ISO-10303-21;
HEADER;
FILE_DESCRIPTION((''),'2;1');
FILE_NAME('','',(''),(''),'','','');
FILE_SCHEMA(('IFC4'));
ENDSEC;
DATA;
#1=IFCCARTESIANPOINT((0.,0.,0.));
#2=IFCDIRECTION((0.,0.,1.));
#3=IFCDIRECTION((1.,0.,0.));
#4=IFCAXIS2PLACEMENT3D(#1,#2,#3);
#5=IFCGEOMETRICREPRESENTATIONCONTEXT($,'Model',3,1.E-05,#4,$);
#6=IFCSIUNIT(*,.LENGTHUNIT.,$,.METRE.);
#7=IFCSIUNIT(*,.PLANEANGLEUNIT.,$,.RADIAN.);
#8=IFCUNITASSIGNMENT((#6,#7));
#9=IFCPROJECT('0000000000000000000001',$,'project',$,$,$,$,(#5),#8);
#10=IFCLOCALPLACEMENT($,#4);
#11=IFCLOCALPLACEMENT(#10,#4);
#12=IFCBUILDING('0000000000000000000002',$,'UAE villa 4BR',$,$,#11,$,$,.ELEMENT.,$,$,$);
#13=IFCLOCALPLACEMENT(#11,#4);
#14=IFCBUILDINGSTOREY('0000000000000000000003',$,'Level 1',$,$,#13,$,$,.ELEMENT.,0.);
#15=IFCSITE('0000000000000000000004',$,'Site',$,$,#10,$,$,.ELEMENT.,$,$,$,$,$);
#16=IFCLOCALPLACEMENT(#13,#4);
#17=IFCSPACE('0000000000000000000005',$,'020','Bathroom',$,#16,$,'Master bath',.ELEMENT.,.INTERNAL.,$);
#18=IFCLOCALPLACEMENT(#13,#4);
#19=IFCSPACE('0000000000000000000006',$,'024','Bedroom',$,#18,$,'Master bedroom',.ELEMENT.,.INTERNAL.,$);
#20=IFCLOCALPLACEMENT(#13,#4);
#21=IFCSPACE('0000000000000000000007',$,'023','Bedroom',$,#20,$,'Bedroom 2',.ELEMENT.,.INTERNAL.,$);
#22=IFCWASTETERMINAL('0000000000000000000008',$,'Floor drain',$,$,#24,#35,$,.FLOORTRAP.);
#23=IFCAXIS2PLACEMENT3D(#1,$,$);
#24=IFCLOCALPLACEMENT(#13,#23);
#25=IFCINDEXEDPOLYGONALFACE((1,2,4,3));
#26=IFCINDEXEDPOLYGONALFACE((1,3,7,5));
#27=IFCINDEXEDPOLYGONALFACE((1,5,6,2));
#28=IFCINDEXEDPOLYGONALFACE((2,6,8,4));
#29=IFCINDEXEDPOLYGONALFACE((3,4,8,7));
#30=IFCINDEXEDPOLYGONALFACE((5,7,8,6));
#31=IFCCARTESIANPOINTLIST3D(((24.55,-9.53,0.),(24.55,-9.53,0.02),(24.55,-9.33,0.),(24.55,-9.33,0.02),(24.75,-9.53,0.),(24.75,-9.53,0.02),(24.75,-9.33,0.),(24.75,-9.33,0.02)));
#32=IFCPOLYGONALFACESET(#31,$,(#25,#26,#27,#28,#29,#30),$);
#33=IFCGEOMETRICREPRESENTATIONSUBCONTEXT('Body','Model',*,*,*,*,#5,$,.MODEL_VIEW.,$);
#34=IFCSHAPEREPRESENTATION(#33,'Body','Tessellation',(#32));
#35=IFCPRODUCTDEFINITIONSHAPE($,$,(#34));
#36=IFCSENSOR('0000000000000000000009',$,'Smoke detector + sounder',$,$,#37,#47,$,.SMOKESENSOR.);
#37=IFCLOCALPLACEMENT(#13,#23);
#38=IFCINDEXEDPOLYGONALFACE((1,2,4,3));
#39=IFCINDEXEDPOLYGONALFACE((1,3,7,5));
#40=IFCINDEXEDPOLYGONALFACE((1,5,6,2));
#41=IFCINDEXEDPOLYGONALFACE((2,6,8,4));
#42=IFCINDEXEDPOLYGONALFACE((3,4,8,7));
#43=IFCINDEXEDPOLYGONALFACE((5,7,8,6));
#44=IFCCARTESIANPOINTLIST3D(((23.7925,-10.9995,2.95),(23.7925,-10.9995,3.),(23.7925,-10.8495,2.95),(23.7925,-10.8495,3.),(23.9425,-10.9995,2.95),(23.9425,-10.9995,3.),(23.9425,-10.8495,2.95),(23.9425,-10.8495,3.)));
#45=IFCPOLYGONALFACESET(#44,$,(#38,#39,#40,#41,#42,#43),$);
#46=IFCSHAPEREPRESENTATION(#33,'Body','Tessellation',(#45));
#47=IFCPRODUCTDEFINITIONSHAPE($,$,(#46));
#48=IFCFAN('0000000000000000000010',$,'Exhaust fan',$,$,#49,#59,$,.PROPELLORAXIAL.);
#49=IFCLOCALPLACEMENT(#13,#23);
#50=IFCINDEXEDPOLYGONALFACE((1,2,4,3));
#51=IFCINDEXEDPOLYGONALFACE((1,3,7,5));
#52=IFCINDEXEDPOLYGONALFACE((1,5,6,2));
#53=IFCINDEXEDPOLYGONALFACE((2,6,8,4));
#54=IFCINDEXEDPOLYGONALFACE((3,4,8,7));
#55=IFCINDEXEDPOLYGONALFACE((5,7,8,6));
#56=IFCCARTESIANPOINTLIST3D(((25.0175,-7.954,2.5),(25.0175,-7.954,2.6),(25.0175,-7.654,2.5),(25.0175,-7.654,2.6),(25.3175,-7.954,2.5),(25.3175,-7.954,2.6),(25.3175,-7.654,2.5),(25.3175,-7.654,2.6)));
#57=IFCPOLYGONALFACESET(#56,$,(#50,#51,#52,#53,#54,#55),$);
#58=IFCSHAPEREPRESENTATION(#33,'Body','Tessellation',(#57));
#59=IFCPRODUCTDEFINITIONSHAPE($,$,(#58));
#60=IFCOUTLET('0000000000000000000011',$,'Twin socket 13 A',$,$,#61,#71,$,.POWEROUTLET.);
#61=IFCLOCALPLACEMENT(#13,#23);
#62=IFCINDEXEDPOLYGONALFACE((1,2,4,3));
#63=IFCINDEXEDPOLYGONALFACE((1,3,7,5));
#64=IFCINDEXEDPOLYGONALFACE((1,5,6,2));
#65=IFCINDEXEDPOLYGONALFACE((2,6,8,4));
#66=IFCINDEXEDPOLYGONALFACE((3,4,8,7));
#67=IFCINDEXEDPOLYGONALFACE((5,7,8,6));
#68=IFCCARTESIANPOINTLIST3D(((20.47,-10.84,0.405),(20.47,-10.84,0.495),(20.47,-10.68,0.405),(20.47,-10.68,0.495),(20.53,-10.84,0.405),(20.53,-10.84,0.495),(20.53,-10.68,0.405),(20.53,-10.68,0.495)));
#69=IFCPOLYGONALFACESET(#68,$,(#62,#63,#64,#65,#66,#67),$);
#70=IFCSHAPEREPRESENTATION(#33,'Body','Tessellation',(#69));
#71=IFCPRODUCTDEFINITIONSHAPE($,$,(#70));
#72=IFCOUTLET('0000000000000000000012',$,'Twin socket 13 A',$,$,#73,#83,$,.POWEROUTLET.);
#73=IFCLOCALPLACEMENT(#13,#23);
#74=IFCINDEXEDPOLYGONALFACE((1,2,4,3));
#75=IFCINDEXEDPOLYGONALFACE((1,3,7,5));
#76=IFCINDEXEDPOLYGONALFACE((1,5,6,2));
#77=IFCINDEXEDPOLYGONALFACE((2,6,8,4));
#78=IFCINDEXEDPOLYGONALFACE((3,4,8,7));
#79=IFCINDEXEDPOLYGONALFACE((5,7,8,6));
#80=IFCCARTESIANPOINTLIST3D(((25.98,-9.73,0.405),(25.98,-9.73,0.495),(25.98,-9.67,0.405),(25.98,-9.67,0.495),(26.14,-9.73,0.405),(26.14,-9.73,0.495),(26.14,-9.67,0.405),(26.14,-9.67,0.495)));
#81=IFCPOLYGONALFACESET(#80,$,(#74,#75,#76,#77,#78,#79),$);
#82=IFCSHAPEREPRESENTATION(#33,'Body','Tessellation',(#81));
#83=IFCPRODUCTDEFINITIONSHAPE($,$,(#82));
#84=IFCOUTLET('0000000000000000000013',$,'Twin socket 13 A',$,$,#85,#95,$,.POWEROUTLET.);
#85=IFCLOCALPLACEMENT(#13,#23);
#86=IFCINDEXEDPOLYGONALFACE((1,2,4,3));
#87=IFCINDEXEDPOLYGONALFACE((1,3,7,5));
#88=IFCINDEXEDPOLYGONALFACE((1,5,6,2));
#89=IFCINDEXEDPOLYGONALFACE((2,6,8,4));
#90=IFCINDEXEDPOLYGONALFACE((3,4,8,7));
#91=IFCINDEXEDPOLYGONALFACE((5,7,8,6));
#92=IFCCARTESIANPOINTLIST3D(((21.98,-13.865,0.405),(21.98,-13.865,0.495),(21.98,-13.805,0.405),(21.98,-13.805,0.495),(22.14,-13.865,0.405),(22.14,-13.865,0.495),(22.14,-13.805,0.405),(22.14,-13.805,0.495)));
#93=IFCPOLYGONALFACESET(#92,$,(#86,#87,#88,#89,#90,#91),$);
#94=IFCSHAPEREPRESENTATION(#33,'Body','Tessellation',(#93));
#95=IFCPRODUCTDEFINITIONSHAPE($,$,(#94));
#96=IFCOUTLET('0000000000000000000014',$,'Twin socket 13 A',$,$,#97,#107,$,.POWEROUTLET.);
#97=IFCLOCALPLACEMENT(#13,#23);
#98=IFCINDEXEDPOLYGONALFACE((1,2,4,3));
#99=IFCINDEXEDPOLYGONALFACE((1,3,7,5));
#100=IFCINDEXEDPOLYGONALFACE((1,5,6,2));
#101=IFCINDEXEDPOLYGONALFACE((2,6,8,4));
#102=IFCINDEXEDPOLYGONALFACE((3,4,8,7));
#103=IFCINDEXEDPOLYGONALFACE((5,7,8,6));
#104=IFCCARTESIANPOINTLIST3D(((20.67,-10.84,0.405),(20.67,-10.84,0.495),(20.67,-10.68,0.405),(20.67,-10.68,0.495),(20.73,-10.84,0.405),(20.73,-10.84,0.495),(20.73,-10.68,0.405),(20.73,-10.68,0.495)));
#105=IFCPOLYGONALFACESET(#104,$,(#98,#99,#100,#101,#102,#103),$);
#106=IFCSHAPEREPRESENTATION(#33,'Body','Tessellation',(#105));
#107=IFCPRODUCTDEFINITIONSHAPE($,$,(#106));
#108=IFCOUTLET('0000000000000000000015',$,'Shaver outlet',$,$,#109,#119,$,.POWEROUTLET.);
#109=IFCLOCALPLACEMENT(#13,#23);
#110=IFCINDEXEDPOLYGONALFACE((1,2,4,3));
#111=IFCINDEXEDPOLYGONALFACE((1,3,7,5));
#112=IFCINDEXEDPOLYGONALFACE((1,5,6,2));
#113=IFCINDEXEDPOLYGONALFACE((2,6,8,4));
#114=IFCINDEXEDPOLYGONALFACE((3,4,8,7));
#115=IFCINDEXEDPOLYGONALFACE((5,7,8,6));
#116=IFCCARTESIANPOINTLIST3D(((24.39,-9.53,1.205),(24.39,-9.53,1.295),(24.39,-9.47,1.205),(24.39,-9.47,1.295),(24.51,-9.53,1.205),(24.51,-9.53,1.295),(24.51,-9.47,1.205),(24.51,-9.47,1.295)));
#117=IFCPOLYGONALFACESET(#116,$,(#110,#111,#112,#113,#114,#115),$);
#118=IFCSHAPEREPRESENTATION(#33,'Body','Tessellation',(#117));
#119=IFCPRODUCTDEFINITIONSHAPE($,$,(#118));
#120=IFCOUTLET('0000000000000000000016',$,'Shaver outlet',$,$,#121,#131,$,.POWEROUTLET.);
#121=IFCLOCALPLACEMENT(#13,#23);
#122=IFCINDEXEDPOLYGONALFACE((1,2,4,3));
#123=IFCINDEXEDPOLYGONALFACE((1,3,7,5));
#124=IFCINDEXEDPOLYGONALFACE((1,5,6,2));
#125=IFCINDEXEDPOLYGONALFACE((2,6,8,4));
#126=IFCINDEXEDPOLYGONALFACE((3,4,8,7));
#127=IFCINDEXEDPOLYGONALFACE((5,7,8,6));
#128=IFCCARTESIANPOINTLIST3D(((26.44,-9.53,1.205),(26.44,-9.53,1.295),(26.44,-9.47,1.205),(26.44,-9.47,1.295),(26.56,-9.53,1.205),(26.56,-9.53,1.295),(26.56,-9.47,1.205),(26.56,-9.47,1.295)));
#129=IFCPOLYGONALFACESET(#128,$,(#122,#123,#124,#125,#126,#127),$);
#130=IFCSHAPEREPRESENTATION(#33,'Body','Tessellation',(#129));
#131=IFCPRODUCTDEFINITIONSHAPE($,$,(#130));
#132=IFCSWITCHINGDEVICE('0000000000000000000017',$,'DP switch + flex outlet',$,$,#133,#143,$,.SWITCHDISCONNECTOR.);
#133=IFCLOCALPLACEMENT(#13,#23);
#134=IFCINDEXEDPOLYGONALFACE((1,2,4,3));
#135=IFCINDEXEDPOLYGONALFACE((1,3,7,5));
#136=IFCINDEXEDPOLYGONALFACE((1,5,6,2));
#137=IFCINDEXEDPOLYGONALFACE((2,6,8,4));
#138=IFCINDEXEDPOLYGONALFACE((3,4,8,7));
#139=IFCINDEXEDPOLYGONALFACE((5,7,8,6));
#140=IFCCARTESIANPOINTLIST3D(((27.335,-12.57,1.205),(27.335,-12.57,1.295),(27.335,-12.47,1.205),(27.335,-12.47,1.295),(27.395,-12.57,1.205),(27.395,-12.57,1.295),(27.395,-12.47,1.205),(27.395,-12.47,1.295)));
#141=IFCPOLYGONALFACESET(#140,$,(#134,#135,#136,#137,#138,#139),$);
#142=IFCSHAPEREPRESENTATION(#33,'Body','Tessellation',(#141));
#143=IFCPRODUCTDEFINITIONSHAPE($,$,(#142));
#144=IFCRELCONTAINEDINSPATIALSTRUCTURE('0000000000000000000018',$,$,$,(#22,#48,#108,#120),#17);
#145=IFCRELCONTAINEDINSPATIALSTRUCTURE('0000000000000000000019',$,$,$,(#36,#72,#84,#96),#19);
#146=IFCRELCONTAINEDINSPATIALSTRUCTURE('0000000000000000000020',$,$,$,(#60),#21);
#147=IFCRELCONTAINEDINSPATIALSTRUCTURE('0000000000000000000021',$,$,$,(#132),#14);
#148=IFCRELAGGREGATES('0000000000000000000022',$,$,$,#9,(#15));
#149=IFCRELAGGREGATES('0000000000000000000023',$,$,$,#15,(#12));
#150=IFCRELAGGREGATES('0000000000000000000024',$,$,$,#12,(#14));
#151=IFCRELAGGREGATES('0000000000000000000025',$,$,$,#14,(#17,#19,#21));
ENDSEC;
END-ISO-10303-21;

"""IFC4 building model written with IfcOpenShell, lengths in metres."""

from ifc_helpers import new_model, si_unit, frame, origin, origin_with_axes, origin_2d, place, context, subcontext, project, spatial, rectangle, extrude, element, save


model = new_model("IFC4")

# Units and contexts
model_context = context("Model", 3, precision=1e-05, world=origin_with_axes())
body_context = subcontext(model_context, "Body", "Model", "MODEL_VIEW")
ifc_project = project(units=[si_unit("LENGTHUNIT", "METRE"), si_unit("PLANEANGLEUNIT", "RADIAN")], contexts=[model_context])

# Site, building, storey
site_placement = place(None, origin_with_axes())
site = spatial("IfcSite", under=ifc_project, at=site_placement, Name="Site", CompositionType="ELEMENT")
building_placement = place(site_placement, origin_with_axes())
building = spatial("IfcBuilding", under=site, at=building_placement, Name="UAE villa 4BR", CompositionType="ELEMENT")
storey_placement = place(building_placement, origin_with_axes())
storey = spatial("IfcBuildingStorey", under=building, at=storey_placement, Name="Level 1", CompositionType="ELEMENT", Elevation=0.0)

# Shared definitions
space_1_placement = place(storey_placement, origin_with_axes())
space_1 = spatial("IfcSpace", under=storey, at=space_1_placement, Name="020", Description="Bathroom", LongName="Master bath", CompositionType="ELEMENT", PredefinedType="INTERNAL")

# Waste terminal
waste_terminal_1_placement = place(storey_placement, frame((24.65, -9.43, 0.0), z_axis=(0.0, 0.0, 1.0), x_axis=(-1.0, 0.0, 0.0)))
element("IfcWasteTerminal", 1, at=waste_terminal_1_placement, inside=space_1, Name="Floor drain", PredefinedType="FLOORTRAP", context=body_context, shape_type="SweptSolid", body=[
    extrude(rectangle(XDim=0.2, YDim=0.2, at=origin_2d()), origin(), (0.0, 0.0, 1.0), 0.02),
])

# Shared definitions
space_2_placement = place(storey_placement, origin_with_axes())
space_2 = spatial("IfcSpace", under=storey, at=space_2_placement, Name="024", Description="Bedroom", LongName="Master bedroom", CompositionType="ELEMENT", PredefinedType="INTERNAL")

# Sensor
sensor_placement = place(storey_placement, frame((23.8675, -10.9245, 2.95), z_axis=(0.0, 0.0, 1.0), x_axis=(1.0, 0.0, 0.0)))
element("IfcSensor", 2, at=sensor_placement, inside=space_2, Name="Smoke detector + sounder", PredefinedType="SMOKESENSOR", context=body_context, shape_type="SweptSolid", body=[
    extrude(rectangle(XDim=0.15, YDim=0.15, at=origin_2d()), origin(), (0.0, 0.0, 1.0), 0.05),
])

# Fan
fan_placement = place(storey_placement, frame((25.1675, -7.804, 2.5), z_axis=(0.0, 0.0, 1.0), x_axis=(1.0, 0.0, 0.0)))
element("IfcFan", 3, at=fan_placement, inside=space_1, Name="Exhaust fan", PredefinedType="PROPELLORAXIAL", context=body_context, shape_type="SweptSolid", body=[
    extrude(rectangle(XDim=0.3, YDim=0.3, at=origin_2d()), origin(), (0.0, 0.0, 1.0), 0.1),
])

# Shared definitions
space_3_placement = place(storey_placement, origin_with_axes())
space_3 = spatial("IfcSpace", under=storey, at=space_3_placement, Name="023", Description="Bedroom", LongName="Bedroom 2", CompositionType="ELEMENT", PredefinedType="INTERNAL")

# Outlets
outlet_placement = place(storey_placement, frame((20.5, -10.76, 0.405), z_axis=(0.0, 0.0, 1.0), x_axis=(0.0, -1.0, 0.0)))
element("IfcOutlet", 4, at=outlet_placement, inside=space_3, Name="Twin socket 13 A", PredefinedType="POWEROUTLET", context=body_context, shape_type="SweptSolid", body=[
    extrude(rectangle(XDim=0.16, YDim=0.06, at=origin_2d()), origin(), (0.0, 0.0, 1.0), 0.09),
])
for number, where, z_axis, x_axis, name in (
    (5, (26.06, -9.7, 0.405), (0.0, 0.0, 1.0), (1.0, 0.0, 0.0), "Twin socket 13 A"),
    (6, (22.06, -13.835, 0.405), (0.0, 0.0, 1.0), (-1.0, 0.0, 0.0), "Twin socket 13 A"),
    (7, (20.7, -10.76, 0.405), (0.0, 0.0, 1.0), (0.0, 1.0, 0.0), "Twin socket 13 A"),
):
    element("IfcOutlet", number, at=place(storey_placement, frame(where, z_axis=z_axis, x_axis=x_axis)), inside=space_2, Name=name, PredefinedType="POWEROUTLET", context=body_context, shape_type="SweptSolid", body=[
        extrude(rectangle(XDim=0.16, YDim=0.06, at=origin_2d()), origin(), (0.0, 0.0, 1.0), 0.09),
    ])
for number, where, z_axis, x_axis, name in (
    (8, (24.45, -9.5, 1.205), (0.0, 0.0, 1.0), (-1.0, 0.0, 0.0), "Shaver outlet"),
    (9, (26.5, -9.5, 1.205), (0.0, 0.0, 1.0), (-1.0, 0.0, 0.0), "Shaver outlet"),
):
    element("IfcOutlet", number, at=place(storey_placement, frame(where, z_axis=z_axis, x_axis=x_axis)), inside=space_1, Name=name, PredefinedType="POWEROUTLET", context=body_context, shape_type="SweptSolid", body=[
        extrude(rectangle(XDim=0.12, YDim=0.06, at=origin_2d()), origin(), (0.0, 0.0, 1.0), 0.09),
    ])

# Switching device
switching_device_placement = place(storey_placement, frame((27.365, -12.52, 1.205), z_axis=(0.0, 0.0, 1.0), x_axis=(0.0, 1.0, 0.0)))
element("IfcSwitchingDevice", 10, at=switching_device_placement, inside=storey, Name="DP switch + flex outlet", PredefinedType="SWITCHDISCONNECTOR", context=body_context, shape_type="SweptSolid", body=[
    extrude(rectangle(XDim=0.1, YDim=0.06, at=origin_2d()), origin(), (0.0, 0.0, 1.0), 0.09),
])

save(model, "model.ifc")
